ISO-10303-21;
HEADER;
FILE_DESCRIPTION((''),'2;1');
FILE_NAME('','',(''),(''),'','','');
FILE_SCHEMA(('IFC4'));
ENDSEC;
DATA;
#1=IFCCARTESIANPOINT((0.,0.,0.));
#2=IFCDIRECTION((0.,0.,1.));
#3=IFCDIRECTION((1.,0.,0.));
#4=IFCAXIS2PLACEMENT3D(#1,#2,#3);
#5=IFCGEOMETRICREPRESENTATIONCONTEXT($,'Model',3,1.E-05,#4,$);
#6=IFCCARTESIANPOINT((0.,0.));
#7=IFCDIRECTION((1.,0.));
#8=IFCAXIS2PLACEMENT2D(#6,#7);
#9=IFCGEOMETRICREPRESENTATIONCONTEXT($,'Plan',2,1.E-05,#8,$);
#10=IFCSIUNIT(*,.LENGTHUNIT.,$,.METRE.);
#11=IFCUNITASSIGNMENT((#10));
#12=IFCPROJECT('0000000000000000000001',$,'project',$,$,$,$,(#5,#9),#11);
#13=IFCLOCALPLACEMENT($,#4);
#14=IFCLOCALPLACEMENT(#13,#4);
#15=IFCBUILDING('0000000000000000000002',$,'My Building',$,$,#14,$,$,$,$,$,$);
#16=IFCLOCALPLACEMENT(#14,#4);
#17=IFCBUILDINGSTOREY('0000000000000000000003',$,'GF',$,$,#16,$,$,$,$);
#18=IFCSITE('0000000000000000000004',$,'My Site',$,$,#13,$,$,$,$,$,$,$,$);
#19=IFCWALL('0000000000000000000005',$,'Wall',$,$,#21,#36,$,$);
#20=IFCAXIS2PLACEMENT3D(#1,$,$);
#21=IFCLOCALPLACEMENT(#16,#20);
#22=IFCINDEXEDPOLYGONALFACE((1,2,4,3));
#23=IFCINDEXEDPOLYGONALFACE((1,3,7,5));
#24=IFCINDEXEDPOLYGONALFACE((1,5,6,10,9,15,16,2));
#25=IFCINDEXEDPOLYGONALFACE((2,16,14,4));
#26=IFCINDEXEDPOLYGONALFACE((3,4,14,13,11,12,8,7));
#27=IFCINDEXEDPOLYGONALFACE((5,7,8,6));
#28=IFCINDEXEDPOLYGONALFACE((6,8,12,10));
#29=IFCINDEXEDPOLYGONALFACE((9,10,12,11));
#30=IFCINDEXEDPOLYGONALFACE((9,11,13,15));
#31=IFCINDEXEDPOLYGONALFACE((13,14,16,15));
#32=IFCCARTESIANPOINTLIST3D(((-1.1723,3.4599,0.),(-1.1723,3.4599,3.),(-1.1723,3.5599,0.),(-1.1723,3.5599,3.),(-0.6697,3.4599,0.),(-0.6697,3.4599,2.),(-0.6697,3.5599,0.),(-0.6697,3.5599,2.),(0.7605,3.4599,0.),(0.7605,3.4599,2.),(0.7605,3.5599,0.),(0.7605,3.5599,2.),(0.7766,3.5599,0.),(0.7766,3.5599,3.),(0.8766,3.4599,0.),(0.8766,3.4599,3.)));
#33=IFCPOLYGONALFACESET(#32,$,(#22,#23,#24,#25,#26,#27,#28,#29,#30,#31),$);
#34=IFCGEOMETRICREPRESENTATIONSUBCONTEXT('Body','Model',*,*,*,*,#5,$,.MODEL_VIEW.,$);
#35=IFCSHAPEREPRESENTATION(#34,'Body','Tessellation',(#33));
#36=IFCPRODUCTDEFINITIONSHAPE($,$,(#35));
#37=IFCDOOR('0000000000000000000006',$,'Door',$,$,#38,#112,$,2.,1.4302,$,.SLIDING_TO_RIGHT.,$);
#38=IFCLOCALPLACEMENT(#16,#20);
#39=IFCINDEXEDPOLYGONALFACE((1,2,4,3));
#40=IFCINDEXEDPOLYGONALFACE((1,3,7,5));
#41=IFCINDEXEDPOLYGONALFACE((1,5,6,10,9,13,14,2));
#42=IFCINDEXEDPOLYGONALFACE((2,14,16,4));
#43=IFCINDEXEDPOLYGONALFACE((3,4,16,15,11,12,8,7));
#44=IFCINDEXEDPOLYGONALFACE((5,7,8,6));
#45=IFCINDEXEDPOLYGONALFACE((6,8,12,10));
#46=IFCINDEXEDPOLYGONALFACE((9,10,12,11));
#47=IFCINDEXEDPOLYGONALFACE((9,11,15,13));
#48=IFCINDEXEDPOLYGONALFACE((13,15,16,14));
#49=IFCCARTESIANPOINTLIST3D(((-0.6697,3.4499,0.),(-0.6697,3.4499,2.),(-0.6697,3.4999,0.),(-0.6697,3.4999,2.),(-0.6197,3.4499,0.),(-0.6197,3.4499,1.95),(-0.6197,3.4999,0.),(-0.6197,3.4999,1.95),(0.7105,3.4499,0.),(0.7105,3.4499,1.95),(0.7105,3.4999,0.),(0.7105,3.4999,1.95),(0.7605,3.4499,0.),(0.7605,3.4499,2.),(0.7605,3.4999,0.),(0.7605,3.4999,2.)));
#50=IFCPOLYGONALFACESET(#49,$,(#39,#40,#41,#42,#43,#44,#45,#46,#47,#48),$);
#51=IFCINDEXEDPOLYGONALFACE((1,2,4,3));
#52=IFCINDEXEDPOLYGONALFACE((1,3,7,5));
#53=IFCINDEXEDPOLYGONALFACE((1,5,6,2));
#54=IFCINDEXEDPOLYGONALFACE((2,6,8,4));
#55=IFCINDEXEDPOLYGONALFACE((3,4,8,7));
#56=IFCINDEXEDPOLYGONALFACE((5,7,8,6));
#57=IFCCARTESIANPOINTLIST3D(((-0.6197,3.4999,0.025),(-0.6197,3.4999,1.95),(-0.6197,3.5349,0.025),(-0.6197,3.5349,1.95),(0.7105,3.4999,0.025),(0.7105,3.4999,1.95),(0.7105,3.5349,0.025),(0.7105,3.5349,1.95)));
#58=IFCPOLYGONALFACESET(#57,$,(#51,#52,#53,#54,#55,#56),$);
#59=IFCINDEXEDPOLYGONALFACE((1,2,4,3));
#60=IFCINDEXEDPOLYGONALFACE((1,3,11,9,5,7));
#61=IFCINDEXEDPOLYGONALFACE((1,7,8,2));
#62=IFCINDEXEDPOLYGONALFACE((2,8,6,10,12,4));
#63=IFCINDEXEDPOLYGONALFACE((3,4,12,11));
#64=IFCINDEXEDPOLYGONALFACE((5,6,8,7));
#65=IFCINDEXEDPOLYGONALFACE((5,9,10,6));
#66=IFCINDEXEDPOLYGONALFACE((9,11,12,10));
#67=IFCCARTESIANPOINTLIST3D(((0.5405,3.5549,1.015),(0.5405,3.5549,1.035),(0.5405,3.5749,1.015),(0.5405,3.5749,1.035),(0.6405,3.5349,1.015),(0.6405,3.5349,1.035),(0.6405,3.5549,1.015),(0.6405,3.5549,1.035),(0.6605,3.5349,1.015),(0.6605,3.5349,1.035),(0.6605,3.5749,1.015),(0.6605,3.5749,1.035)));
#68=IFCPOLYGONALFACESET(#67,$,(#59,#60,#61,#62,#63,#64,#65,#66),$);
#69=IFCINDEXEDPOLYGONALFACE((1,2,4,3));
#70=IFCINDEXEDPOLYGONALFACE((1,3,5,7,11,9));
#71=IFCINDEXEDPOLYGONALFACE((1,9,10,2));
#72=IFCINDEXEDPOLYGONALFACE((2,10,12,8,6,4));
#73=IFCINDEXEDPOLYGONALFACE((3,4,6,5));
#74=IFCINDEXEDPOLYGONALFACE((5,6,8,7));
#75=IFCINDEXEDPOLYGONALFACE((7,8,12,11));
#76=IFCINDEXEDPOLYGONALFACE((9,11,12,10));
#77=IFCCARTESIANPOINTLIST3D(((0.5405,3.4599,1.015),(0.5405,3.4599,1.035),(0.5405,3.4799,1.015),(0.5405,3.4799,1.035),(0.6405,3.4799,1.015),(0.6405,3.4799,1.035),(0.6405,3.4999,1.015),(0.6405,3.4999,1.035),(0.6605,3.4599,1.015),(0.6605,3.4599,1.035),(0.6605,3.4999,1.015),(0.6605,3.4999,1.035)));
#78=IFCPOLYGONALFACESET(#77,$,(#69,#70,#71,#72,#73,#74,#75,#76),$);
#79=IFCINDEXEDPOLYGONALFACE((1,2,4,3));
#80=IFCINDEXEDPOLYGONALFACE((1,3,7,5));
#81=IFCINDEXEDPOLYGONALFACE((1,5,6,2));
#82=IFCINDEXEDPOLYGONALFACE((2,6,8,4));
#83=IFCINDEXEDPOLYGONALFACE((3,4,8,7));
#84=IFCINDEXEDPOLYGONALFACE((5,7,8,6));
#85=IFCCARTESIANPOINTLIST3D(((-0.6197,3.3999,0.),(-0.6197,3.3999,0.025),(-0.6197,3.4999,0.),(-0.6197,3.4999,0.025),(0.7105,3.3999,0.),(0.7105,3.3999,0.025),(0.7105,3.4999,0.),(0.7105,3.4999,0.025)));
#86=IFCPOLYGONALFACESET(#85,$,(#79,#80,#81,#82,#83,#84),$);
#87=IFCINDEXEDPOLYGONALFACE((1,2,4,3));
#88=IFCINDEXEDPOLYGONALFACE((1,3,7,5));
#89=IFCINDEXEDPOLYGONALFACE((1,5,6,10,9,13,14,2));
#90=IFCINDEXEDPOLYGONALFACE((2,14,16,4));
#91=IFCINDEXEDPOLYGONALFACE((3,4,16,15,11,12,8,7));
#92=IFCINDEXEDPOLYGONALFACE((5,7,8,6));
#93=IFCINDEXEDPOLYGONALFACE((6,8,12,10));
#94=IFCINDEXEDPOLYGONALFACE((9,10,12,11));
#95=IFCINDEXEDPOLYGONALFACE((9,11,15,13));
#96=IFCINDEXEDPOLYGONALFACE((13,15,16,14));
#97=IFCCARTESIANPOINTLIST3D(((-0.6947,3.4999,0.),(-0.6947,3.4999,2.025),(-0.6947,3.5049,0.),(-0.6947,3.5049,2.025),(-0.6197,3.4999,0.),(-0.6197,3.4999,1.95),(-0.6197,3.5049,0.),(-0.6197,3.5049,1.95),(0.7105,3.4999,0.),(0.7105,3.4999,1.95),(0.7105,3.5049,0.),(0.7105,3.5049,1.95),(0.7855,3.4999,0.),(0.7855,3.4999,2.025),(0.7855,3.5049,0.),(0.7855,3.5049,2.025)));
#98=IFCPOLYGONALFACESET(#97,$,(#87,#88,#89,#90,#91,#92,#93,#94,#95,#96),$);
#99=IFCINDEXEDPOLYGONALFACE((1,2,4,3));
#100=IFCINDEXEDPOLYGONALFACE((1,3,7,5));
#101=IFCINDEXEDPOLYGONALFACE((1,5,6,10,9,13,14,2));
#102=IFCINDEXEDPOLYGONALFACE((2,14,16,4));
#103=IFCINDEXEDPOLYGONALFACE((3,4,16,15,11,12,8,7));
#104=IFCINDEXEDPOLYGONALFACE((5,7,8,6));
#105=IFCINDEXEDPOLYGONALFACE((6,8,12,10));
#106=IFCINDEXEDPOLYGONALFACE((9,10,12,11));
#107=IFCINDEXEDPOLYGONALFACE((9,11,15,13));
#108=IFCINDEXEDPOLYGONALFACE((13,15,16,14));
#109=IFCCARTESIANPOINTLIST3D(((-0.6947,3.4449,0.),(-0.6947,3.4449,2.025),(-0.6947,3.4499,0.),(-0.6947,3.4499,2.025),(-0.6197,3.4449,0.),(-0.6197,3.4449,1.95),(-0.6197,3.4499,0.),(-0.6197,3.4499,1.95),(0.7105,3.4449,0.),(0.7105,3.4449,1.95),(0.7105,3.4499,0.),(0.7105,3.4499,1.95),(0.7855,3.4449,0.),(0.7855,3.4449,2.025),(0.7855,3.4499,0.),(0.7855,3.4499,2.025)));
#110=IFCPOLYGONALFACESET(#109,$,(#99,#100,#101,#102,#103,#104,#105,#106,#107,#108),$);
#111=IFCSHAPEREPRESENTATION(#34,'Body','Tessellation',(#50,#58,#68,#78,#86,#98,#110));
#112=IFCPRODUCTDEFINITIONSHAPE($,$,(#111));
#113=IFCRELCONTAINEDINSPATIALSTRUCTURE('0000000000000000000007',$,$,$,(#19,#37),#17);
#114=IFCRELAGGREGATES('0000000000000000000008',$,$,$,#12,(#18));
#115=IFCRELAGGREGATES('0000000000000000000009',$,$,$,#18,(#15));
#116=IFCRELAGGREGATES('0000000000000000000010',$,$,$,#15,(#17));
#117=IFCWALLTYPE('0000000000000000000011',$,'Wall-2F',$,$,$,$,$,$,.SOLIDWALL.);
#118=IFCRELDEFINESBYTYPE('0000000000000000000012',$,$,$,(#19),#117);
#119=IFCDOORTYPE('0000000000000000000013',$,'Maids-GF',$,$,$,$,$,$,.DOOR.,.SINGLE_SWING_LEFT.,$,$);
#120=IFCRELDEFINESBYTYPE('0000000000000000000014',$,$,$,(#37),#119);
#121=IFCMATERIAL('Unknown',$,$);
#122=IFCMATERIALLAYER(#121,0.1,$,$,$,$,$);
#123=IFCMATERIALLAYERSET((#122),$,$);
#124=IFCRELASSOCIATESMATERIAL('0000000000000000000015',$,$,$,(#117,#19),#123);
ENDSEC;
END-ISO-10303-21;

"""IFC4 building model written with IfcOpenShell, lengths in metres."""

from ifc_helpers import new_model, entity, si_unit, frame, origin_with_axes, origin_2d_with_axis, place, context, subcontext, project, spatial, line, indexed_curve, outline, extrude, shape, source, transform, mapped, material, layer, layer_set, layer_usage, type_object, type_shapes, element, fill, save


model = new_model("IFC4")

# Units and contexts
model_context = context("Model", 3, precision=1e-05, world=origin_with_axes())
plan_context = context("Plan", 2, precision=1e-05, world=origin_2d_with_axis())
body_context_1 = subcontext(model_context, "Body", "Model", "MODEL_VIEW")
body_context_2 = subcontext(plan_context, "Body", "Plan", "PLAN_VIEW")
ifc_project = project(units=[si_unit("LENGTHUNIT", "METRE")], contexts=[model_context, plan_context])

# Site, building, storey
site_placement = place(None, origin_with_axes())
site = spatial("IfcSite", under=ifc_project, at=site_placement, Name="My Site")
building_placement = place(site_placement, origin_with_axes())
building = spatial("IfcBuilding", under=site, at=building_placement, Name="My Building")
storey_placement = place(building_placement, origin_with_axes())
storey = spatial("IfcBuildingStorey", under=building, at=storey_placement, Name="GF")

# Shared definitions
ifc_material = material(Name="Unknown")

# Shared definitions
ifc_layer_1 = layer(ifc_material, 0.1)
ifc_layer_set_1 = layer_set([ifc_layer_1])
wall_type = type_object("IfcWallType", Name="Wall-2F", PredefinedType="SOLIDWALL", material=ifc_layer_set_1)

# Wall, opening, door
ifc_layer_usage_1 = layer_usage(ifc_layer_set_1, "AXIS2", "POSITIVE", 0.0)
wall_1_placement = place(storey_placement, frame((0.7766, 3.5599, 0.0), z_axis=(0.0, 0.0, 1.0), x_axis=(-1.0, 0.0, 0.0)))
wall_1 = element("IfcWall", 1, at=wall_1_placement, inside=storey, type_object=wall_type, material=ifc_layer_usage_1, Name="Wall", context=body_context_1, shape_type="SweptSolid", body=[
    extrude(outline(indexed_curve([(0.0, 0.0), (-0.1, 0.1), (1.9489, 0.1), (1.9489, 0.0)], segments=[line(1, 2, 3, 4, 1)])), origin_with_axes(), (0.0, 0.0, 1.0), 3.0),
])
shared_shape_1 = source(origin_with_axes(), body_context_1, "Body", "SweptSolid", [
    extrude(outline(indexed_curve([(0.0, 0.0), (1.4302, 0.0), (1.4302, 2.0), (0.0, 2.0)], segments=[line(1, 2, 3, 4, 1)])), frame((0.0, -0.6, 0.0), z_axis=(0.0, -1.0, 0.0), x_axis=(1.0, 0.0, 0.0)), (0.0, 0.0, -1.0), 1.2),
])
opening_1_placement = place(wall_1_placement, frame((0.0161, 0.06, 0.0), z_axis=(0.0, 0.0, 1.0), x_axis=(1.0, -0.000002, 0.0)))
opening_1 = element("IfcOpeningElement", 2, at=opening_1_placement, cuts=wall_1, PredefinedType="OPENING", context=body_context_1, shape_type="MappedRepresentation", body=[
    mapped(shared_shape_1, transform((0.0, 0.0, 0.0), x_axis=(1.0, 0.0, 0.0), y_axis=(0.0, 1.0, 0.0), z_axis=(0.0, 0.0, 1.0), scale=1.0)),
])
door_type_1 = type_object("IfcDoorType", Name="Maids-GF", OperationType="SINGLE_SWING_LEFT", PredefinedType="DOOR")
shared_shape_2 = source(origin_with_axes(), body_context_1, "Body", "SweptSolid", [
    extrude(outline(indexed_curve([(0.0, 0.0), (0.0, 2.0), (1.4302, 2.0), (1.4302, 0.0), (1.3802, 0.0), (1.3802, 1.95), (0.05, 1.95), (0.05, 0.0)], segments=[line(1, 2, 3, 4, 5, 6, 7, 8, 1)])), frame((0.0, 0.0, 0.0), z_axis=(0.0, -1.0, 0.0), x_axis=(1.0, 0.0, 0.0)), (0.0, 0.0, -1.0), 0.05),
    extrude(outline(indexed_curve([(0.0, 0.0), (1.3302, 0.0), (1.3302, 0.035), (0.0, 0.035)], segments=[line(1, 2, 3, 4, 1)])), frame((0.05, -0.035, 0.025), z_axis=(0.0, 0.0, 1.0), x_axis=(1.0, 0.0, 0.0)), (0.0, 0.0, 1.0), 1.925),
    extrude(outline(indexed_curve([(0.0, 0.0), (0.0, -0.04), (0.12, -0.04), (0.12, -0.02), (0.02, -0.02), (0.02, 0.0)], segments=[line(1, 2, 3, 4, 5, 6, 1)])), frame((0.1, -0.035, 1.015), z_axis=(0.0, 0.0, 1.0), x_axis=(1.0, 0.0, 0.0)), (0.0, 0.0, 1.0), 0.02),
    extrude(outline(indexed_curve([(0.0, 0.0), (0.0, 0.04), (0.12, 0.04), (0.12, 0.02), (0.02, 0.02), (0.02, 0.0)], segments=[line(1, 2, 3, 4, 5, 6, 1)])), frame((0.1, 0.0, 1.015), z_axis=(0.0, 0.0, 1.0), x_axis=(1.0, 0.0, 0.0)), (0.0, 0.0, 1.0), 0.02),
    extrude(outline(indexed_curve([(0.0, 0.0), (1.3302, 0.0), (1.3302, 0.1), (0.0, 0.1)], segments=[line(1, 2, 3, 4, 1)])), frame((0.05, 0.0, 0.0), z_axis=(0.0, 0.0, 1.0), x_axis=(1.0, 0.0, 0.0)), (0.0, 0.0, 1.0), 0.025),
    extrude(outline(indexed_curve([(0.0, 0.0), (0.0, 2.025), (1.4802, 2.025), (1.4802, 0.0), (1.4052, 0.0), (1.4052, 1.95), (0.075, 1.95), (0.075, 0.0)], segments=[line(1, 2, 3, 4, 5, 6, 7, 8, 1)])), frame((-0.025, -0.005, 0.0), z_axis=(0.0, -1.0, 0.0), x_axis=(1.0, 0.0, 0.0)), (0.0, 0.0, -1.0), 0.005),
    extrude(outline(indexed_curve([(0.0, 0.0), (0.0, 2.025), (1.4802, 2.025), (1.4802, 0.0), (1.4052, 0.0), (1.4052, 1.95), (0.075, 1.95), (0.075, 0.0)], segments=[line(1, 2, 3, 4, 5, 6, 7, 8, 1)])), frame((-0.025, 0.05, 0.0), z_axis=(0.0, -1.0, 0.0), x_axis=(1.0, 0.0, 0.0)), (0.0, 0.0, -1.0), 0.005),
])
shared_shape_3 = source(origin_with_axes(), body_context_2, "Body", "Curve2D", [
    entity("IfcIndexedPolyCurve", entity("IfcCartesianPointList2D", [[0.0, 0.0], [0.05, 0.0], [0.05, 0.05], [0.0, 0.05]]), [entity("IfcLineIndex", [1, 2, 3, 4, 1])]),
    entity("IfcIndexedPolyCurve", entity("IfcCartesianPointList2D", [[1.4302, 0.0], [1.3802, 0.0], [1.3802, 0.05], [1.4302, 0.05]]), [entity("IfcLineIndex", [1, 2, 3, 4, 1])]),
    entity("IfcIndexedPolyCurve", entity("IfcCartesianPointList2D", [[2.0454, -0.035], [0.7151, -0.035], [0.7151, 0.0], [2.0454, 0.0]]), [entity("IfcLineIndex", [1, 2, 3, 4, 1])]),
])
type_shapes(door_type_1, [shared_shape_2, shared_shape_3])
door_1_placement = place(opening_1_placement, frame((0.0, 0.0, 0.0), z_axis=(0.0, 0.0, 1.0), x_axis=(1.0, 0.0, 0.0)))
door_1 = element("IfcDoor", 3, at=door_1_placement, inside=storey, type_object=door_type_1, Name="Door", OperationType="SLIDING_TO_RIGHT", OverallHeight=2.0, OverallWidth=1.4302, shapes=[
    shape(body_context_1, "Body", "MappedRepresentation", [mapped(shared_shape_2, transform((0.0, 0.0, 0.0), x_axis=(1.0, 0.0, 0.0), y_axis=(0.0, 1.0, 0.0), z_axis=(0.0, 0.0, 1.0), scale=1.0))]),
    shape(body_context_2, "Body", "MappedRepresentation", [mapped(shared_shape_3, transform((0.0, 0.0, 0.0), x_axis=(1.0, 0.0, 0.0), y_axis=(0.0, 1.0, 0.0), z_axis=(0.0, 0.0, 1.0), scale=1.0))]),
])
fill(opening_1, door_1)

save(model, "model.ifc")
